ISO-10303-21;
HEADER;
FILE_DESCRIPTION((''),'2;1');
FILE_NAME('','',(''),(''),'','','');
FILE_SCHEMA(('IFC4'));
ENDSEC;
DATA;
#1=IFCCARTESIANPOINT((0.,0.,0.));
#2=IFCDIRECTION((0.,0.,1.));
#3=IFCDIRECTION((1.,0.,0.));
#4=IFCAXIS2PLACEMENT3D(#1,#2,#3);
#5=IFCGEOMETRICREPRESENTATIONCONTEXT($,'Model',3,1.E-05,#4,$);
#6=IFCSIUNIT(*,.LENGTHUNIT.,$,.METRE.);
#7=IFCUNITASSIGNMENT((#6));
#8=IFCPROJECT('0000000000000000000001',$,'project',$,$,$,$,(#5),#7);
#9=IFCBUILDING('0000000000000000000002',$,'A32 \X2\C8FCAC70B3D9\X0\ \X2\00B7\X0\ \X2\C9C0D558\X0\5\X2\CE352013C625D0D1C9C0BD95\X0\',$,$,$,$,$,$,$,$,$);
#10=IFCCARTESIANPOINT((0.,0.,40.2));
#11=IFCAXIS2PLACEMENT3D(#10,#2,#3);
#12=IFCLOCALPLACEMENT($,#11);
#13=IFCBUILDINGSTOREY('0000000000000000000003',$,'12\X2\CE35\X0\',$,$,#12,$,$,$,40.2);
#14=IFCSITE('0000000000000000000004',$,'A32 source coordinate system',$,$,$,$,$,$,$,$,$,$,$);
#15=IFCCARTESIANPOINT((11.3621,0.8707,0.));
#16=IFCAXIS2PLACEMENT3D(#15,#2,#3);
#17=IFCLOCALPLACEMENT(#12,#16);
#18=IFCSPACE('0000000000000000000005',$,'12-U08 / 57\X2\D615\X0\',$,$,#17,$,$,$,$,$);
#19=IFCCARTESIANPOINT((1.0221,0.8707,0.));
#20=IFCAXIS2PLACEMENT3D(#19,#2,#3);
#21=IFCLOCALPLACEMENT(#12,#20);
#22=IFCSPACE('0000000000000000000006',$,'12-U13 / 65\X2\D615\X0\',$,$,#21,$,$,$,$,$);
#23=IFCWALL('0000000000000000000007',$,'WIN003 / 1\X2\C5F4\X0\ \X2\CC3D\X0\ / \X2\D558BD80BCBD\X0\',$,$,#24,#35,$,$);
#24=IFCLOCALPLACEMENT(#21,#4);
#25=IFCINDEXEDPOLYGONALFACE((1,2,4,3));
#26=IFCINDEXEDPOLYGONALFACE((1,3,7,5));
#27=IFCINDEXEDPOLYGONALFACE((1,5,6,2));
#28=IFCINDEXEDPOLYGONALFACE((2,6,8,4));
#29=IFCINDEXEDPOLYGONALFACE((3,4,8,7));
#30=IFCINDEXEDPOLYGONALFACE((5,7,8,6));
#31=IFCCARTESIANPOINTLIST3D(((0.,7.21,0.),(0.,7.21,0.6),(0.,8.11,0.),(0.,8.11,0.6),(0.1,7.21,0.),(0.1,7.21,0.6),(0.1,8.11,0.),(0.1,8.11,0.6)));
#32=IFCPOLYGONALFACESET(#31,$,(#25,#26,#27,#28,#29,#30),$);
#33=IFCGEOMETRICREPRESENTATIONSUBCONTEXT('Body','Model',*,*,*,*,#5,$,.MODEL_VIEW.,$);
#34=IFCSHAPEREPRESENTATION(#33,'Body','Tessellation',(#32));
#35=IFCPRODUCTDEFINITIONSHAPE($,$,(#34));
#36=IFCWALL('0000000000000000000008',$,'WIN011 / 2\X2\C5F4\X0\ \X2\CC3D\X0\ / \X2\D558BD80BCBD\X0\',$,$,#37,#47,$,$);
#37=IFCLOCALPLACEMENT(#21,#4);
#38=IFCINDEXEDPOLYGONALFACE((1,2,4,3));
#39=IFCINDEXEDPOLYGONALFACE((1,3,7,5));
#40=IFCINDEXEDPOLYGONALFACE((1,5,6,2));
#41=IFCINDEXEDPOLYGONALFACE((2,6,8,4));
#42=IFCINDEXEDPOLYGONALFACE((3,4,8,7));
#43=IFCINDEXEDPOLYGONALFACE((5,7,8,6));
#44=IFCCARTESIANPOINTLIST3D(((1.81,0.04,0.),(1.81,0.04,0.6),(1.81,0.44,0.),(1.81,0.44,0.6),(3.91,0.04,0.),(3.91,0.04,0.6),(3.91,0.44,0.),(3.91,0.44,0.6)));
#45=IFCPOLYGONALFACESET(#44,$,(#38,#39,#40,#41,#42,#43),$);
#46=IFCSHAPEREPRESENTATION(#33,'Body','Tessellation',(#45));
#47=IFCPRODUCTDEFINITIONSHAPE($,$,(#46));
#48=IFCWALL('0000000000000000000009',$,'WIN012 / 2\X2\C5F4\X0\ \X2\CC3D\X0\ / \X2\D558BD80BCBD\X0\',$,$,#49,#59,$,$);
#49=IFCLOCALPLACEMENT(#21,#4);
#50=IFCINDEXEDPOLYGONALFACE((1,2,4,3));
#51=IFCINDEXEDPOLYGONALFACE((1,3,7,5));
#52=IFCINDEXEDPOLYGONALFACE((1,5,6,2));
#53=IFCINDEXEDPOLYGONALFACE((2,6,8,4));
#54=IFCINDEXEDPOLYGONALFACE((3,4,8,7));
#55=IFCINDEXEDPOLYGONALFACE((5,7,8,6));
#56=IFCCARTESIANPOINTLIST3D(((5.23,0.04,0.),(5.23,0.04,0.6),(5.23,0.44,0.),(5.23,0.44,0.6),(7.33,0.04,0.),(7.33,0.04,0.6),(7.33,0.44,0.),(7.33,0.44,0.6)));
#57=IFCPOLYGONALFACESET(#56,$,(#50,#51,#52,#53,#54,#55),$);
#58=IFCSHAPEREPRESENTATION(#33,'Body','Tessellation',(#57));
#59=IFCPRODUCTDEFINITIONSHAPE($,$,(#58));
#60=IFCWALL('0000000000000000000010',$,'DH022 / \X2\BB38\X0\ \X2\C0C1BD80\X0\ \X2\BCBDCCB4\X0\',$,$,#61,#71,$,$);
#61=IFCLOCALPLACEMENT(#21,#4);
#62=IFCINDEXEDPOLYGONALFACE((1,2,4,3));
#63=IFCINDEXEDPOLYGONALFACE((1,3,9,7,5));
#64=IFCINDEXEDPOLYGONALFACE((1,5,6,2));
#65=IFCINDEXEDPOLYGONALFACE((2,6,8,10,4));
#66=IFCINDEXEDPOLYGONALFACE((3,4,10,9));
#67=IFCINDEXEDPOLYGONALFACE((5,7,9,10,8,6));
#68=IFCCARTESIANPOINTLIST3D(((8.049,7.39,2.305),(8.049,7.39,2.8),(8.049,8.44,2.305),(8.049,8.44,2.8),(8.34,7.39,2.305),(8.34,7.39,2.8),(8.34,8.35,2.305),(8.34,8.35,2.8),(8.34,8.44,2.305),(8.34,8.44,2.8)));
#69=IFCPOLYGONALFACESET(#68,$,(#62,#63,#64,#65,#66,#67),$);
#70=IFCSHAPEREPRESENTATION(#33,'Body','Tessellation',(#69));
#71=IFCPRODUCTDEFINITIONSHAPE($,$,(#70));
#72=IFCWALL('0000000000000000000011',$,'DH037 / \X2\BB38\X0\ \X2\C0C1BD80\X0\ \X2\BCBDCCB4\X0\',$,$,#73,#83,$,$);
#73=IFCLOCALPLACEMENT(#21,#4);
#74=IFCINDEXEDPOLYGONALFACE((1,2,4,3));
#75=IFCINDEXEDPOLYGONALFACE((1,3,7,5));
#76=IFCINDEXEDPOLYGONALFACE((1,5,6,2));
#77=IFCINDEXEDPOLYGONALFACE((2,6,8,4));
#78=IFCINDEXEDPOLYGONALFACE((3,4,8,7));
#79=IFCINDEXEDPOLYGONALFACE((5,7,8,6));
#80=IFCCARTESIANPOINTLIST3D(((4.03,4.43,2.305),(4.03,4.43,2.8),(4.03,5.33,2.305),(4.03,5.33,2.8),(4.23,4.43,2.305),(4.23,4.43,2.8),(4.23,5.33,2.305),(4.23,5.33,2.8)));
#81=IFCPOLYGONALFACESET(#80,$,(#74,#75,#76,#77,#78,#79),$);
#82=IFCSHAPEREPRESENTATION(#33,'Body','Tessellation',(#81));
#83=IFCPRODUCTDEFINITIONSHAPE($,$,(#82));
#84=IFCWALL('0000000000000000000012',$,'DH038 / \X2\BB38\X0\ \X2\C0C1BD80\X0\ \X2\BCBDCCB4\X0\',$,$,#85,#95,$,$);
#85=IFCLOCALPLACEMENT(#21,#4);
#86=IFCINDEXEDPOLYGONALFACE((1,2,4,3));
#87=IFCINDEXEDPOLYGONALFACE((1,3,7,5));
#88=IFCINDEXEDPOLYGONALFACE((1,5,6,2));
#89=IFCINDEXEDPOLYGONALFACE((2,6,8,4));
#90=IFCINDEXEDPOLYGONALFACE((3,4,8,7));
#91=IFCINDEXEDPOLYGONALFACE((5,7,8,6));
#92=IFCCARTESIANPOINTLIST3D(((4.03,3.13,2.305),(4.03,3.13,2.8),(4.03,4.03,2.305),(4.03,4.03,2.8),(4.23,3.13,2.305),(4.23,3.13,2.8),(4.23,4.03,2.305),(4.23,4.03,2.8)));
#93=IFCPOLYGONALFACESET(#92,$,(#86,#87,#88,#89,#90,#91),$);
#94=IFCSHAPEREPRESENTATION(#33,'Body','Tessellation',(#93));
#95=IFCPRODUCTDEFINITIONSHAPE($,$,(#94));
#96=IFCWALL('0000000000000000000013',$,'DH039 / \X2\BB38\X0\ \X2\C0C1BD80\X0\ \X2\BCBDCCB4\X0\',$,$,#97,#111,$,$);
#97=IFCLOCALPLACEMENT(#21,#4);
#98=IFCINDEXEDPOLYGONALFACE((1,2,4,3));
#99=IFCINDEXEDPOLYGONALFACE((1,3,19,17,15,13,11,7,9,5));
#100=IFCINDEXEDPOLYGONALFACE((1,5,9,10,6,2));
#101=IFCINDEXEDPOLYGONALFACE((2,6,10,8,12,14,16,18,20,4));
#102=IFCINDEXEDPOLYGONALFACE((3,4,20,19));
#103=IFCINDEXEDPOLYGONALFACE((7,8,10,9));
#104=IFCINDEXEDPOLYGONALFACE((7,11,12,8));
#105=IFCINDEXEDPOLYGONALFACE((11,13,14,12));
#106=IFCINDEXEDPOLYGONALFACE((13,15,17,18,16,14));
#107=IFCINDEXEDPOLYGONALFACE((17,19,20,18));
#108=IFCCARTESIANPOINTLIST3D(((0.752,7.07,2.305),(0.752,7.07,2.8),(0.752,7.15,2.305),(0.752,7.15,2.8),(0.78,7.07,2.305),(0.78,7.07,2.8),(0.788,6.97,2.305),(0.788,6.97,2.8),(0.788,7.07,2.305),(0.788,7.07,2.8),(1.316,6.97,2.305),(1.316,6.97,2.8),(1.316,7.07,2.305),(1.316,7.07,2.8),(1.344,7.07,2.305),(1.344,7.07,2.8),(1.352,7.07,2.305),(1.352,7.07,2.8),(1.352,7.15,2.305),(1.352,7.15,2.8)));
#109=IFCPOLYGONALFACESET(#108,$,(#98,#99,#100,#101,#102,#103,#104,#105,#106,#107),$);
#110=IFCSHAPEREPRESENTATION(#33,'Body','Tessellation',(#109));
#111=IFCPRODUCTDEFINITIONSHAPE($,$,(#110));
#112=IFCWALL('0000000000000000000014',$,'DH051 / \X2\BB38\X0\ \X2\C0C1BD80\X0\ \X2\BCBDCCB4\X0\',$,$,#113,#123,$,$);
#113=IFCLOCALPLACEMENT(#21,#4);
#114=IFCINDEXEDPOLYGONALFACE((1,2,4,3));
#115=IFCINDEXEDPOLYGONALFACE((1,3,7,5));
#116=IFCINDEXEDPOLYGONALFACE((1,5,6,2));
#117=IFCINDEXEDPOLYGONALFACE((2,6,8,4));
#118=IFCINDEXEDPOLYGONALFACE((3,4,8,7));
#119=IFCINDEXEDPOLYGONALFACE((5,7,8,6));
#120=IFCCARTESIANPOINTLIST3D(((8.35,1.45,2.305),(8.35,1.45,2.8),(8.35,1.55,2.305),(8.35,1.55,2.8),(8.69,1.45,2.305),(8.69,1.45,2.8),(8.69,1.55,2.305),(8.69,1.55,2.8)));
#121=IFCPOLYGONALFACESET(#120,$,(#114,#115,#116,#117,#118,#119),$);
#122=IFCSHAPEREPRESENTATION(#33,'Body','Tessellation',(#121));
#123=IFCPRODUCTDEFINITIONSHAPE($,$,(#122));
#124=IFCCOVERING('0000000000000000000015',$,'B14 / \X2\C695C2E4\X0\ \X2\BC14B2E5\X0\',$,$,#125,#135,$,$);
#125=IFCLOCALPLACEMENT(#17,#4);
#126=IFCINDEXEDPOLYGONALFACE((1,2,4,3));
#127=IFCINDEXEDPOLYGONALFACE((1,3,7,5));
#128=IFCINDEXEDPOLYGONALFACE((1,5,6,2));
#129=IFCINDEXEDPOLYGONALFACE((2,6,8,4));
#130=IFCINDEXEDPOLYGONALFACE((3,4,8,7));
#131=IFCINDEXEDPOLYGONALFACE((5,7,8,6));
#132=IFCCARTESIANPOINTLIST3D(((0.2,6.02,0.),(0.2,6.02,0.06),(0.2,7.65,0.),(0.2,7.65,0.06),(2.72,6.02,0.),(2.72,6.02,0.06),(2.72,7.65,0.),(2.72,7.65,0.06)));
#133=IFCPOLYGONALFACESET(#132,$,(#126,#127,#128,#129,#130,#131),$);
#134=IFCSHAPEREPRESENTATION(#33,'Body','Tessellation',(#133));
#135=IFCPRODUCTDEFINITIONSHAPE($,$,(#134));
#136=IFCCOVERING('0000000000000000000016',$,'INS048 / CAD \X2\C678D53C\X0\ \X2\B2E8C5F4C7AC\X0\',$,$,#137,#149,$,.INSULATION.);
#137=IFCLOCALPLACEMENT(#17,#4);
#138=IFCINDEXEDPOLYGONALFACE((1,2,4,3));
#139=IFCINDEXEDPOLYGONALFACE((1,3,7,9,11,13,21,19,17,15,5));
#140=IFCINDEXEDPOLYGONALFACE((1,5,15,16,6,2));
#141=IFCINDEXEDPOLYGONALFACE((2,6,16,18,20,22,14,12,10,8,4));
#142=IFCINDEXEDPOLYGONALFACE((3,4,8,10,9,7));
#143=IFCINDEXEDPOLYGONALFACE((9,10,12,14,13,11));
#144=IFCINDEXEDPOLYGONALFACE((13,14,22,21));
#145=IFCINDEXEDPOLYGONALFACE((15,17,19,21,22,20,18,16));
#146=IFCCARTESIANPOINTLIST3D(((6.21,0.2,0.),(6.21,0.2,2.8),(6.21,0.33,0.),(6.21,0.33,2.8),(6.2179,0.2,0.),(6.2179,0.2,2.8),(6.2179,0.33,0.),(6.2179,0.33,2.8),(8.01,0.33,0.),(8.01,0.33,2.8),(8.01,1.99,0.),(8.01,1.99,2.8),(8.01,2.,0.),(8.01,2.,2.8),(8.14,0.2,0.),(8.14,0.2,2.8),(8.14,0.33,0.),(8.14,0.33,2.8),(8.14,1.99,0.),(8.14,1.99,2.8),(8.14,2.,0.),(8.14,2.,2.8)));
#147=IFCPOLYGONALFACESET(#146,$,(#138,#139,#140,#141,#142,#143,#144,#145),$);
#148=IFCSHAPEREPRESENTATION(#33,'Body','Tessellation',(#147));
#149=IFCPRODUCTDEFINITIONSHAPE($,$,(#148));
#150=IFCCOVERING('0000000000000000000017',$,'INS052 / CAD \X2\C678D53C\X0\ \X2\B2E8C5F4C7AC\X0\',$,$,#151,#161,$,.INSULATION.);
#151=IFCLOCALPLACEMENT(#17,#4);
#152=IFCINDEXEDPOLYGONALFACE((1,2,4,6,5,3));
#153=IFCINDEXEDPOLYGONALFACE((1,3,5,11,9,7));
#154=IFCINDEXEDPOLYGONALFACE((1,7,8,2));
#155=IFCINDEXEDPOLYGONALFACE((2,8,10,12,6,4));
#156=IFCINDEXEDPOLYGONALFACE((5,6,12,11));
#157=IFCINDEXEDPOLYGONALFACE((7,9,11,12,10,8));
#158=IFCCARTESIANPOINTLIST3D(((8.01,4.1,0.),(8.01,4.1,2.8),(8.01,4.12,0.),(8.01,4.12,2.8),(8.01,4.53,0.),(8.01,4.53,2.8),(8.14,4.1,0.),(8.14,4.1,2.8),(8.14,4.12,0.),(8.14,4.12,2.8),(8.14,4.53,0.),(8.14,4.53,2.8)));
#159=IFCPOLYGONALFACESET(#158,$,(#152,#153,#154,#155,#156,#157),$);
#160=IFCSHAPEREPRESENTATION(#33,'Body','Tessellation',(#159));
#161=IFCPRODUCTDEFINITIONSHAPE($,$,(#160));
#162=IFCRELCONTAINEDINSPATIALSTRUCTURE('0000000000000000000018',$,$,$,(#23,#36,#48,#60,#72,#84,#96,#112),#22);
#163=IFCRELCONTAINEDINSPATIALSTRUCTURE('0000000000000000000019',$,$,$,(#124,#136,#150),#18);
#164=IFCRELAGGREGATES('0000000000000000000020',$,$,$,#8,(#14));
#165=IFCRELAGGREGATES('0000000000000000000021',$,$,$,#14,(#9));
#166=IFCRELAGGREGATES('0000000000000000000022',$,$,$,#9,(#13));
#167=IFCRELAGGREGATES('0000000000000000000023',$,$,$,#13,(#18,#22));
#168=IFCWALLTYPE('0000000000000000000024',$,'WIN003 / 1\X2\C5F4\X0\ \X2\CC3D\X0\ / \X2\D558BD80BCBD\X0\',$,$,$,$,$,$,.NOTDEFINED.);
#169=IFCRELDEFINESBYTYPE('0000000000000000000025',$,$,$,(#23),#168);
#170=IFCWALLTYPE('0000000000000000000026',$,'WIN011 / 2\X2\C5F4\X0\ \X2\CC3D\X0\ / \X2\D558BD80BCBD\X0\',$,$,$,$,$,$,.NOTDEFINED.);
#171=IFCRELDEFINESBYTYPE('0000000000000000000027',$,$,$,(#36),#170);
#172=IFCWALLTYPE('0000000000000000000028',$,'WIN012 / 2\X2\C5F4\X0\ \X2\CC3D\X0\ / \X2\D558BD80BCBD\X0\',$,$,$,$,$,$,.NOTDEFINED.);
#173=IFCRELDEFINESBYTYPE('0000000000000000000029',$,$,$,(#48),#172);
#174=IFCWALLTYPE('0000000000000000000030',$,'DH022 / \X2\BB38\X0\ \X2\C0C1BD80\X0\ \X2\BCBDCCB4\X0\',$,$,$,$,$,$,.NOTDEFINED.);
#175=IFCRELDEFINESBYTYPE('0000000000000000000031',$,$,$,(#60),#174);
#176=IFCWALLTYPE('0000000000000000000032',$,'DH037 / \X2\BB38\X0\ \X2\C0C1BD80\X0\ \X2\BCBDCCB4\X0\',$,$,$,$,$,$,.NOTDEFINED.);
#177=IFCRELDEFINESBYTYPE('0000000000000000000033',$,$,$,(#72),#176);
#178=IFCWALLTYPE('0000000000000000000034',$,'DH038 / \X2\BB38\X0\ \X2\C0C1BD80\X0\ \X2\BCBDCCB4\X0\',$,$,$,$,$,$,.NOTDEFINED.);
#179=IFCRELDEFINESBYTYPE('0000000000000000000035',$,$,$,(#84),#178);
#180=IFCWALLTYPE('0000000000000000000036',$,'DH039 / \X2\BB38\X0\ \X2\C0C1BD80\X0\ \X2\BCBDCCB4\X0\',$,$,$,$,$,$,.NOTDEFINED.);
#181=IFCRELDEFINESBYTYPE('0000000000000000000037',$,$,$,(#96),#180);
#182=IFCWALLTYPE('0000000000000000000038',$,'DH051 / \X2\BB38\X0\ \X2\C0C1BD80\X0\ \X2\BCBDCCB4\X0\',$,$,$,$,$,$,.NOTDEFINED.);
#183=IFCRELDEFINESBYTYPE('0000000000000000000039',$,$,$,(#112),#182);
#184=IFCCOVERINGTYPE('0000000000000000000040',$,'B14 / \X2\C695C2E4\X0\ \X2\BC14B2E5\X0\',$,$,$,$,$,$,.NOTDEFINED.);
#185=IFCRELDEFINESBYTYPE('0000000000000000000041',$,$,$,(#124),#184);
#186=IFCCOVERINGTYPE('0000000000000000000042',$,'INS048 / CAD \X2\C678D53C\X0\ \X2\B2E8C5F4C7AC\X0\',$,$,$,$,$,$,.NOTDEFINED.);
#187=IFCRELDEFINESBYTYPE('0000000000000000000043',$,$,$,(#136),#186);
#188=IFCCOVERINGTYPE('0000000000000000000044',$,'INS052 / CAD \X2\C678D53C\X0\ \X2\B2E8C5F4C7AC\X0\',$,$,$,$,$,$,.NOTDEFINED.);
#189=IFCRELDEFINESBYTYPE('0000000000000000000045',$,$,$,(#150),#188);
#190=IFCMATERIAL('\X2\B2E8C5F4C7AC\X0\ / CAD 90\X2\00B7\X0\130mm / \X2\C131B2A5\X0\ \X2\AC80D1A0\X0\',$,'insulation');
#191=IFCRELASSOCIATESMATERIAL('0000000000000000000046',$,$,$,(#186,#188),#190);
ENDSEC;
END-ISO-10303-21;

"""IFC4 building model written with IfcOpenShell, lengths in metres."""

from ifc_helpers import new_model, si_unit, frame, origin, origin_with_axes, place, context, subcontext, project, spatial, polyline, outline, extrude, source, transform, mapped, material, type_object, type_shapes, element, save


model = new_model("IFC4")

# Units and contexts
model_context = context("Model", 3, precision=1e-05, world=origin_with_axes())
body_context = subcontext(model_context, "Body", "Model", "MODEL_VIEW")
ifc_project = project(units=[si_unit("LENGTHUNIT", "METRE")], contexts=[model_context])

# Site, building, storey, space
site = spatial("IfcSite", under=ifc_project, Name="A32 source coordinate system")
building = spatial("IfcBuilding", under=site, Name="A32 주거동 · 지하5층–옥탑지붕")
storey_placement = place(None, frame((0.0, 0.0, 40.2), z_axis=(0.0, 0.0, 1.0), x_axis=(1.0, 0.0, 0.0)))
storey = spatial("IfcBuildingStorey", under=building, at=storey_placement, Name="12층", Elevation=40.2)
space_1_placement = place(storey_placement, frame((11.3621, 0.8707, 0.0), z_axis=(0.0, 0.0, 1.0), x_axis=(1.0, 0.0, 0.0)))
space_1 = spatial("IfcSpace", under=storey, at=space_1_placement, Name="12-U08 / 57형")

# Shared definitions
space_2_placement = place(storey_placement, frame((1.0221, 0.8707, 0.0), z_axis=(0.0, 0.0, 1.0), x_axis=(1.0, 0.0, 0.0)))
space_2 = spatial("IfcSpace", under=storey, at=space_2_placement, Name="12-U13 / 65형")

# Walls
wall_type_1 = type_object("IfcWallType", Name="WIN003 / 1열 창 / 하부벽", PredefinedType="NOTDEFINED")
shared_shape_1 = source(origin(), body_context, "Body", "SweptSolid", [
    extrude(outline(polyline([(0.0, 8.11), (0.1, 8.11), (0.1, 7.21), (0.0, 7.21), (0.0, 8.11)])), origin(), (0.0, 0.0, 1.0), 0.6),
])
type_shapes(wall_type_1, [shared_shape_1])
wall_1_placement = place(space_2_placement, origin_with_axes())
element("IfcWall", 1, at=wall_1_placement, inside=space_2, type_object=wall_type_1, Name="WIN003 / 1열 창 / 하부벽", context=body_context, shape_type="MappedRepresentation", body=[
    mapped(shared_shape_1, transform((0.0, 0.0, 0.0), scale=1.0)),
])
wall_type_2 = type_object("IfcWallType", Name="WIN011 / 2열 창 / 하부벽", PredefinedType="NOTDEFINED")
shared_shape_2 = source(origin(), body_context, "Body", "SweptSolid", [
    extrude(outline(polyline([(1.81, 0.44), (3.91, 0.44), (3.91, 0.04), (1.81, 0.04), (1.81, 0.44)])), origin(), (0.0, 0.0, 1.0), 0.6),
])
type_shapes(wall_type_2, [shared_shape_2])
wall_2_placement = place(space_2_placement, origin_with_axes())
element("IfcWall", 2, at=wall_2_placement, inside=space_2, type_object=wall_type_2, Name="WIN011 / 2열 창 / 하부벽", context=body_context, shape_type="MappedRepresentation", body=[
    mapped(shared_shape_2, transform((0.0, 0.0, 0.0), scale=1.0)),
])
wall_type_3 = type_object("IfcWallType", Name="WIN012 / 2열 창 / 하부벽", PredefinedType="NOTDEFINED")
shared_shape_3 = source(origin(), body_context, "Body", "SweptSolid", [
    extrude(outline(polyline([(5.23, 0.44), (7.33, 0.44), (7.33, 0.04), (5.23, 0.04), (5.23, 0.44)])), origin(), (0.0, 0.0, 1.0), 0.6),
])
type_shapes(wall_type_3, [shared_shape_3])
wall_3_placement = place(space_2_placement, origin_with_axes())
element("IfcWall", 3, at=wall_3_placement, inside=space_2, type_object=wall_type_3, Name="WIN012 / 2열 창 / 하부벽", context=body_context, shape_type="MappedRepresentation", body=[
    mapped(shared_shape_3, transform((0.0, 0.0, 0.0), scale=1.0)),
])
wall_type_4 = type_object("IfcWallType", Name="DH022 / 문 상부 벽체", PredefinedType="NOTDEFINED")
shared_shape_4 = source(origin(), body_context, "Body", "SweptSolid", [
    extrude(outline(polyline([(8.049, 7.39), (8.049, 8.44), (8.34, 8.44), (8.34, 8.35), (8.34, 8.35), (8.34, 7.39), (8.049, 7.39)])), frame((0.0, 0.0, 2.305)), (0.0, 0.0, 1.0), 0.495),
])
type_shapes(wall_type_4, [shared_shape_4])
wall_4_placement = place(space_2_placement, origin_with_axes())
element("IfcWall", 4, at=wall_4_placement, inside=space_2, type_object=wall_type_4, Name="DH022 / 문 상부 벽체", context=body_context, shape_type="MappedRepresentation", body=[
    mapped(shared_shape_4, transform((0.0, 0.0, 0.0), scale=1.0)),
])
wall_type_5 = type_object("IfcWallType", Name="DH037 / 문 상부 벽체", PredefinedType="NOTDEFINED")
shared_shape_5 = source(origin(), body_context, "Body", "SweptSolid", [
    extrude(outline(polyline([(4.23, 5.33), (4.23, 4.43), (4.03, 4.43), (4.03, 5.33), (4.23, 5.33)])), frame((0.0, 0.0, 2.305)), (0.0, 0.0, 1.0), 0.495),
])
type_shapes(wall_type_5, [shared_shape_5])
wall_5_placement = place(space_2_placement, origin_with_axes())
element("IfcWall", 5, at=wall_5_placement, inside=space_2, type_object=wall_type_5, Name="DH037 / 문 상부 벽체", context=body_context, shape_type="MappedRepresentation", body=[
    mapped(shared_shape_5, transform((0.0, 0.0, 0.0), scale=1.0)),
])
wall_type_6 = type_object("IfcWallType", Name="DH038 / 문 상부 벽체", PredefinedType="NOTDEFINED")
shared_shape_6 = source(origin(), body_context, "Body", "SweptSolid", [
    extrude(outline(polyline([(4.23, 4.03), (4.23, 3.13), (4.03, 3.13), (4.03, 4.03), (4.23, 4.03)])), frame((0.0, 0.0, 2.305)), (0.0, 0.0, 1.0), 0.495),
])
type_shapes(wall_type_6, [shared_shape_6])
wall_6_placement = place(space_2_placement, origin_with_axes())
element("IfcWall", 6, at=wall_6_placement, inside=space_2, type_object=wall_type_6, Name="DH038 / 문 상부 벽체", context=body_context, shape_type="MappedRepresentation", body=[
    mapped(shared_shape_6, transform((0.0, 0.0, 0.0), scale=1.0)),
])
wall_type_7 = type_object("IfcWallType", Name="DH039 / 문 상부 벽체", PredefinedType="NOTDEFINED")
shared_shape_7 = source(origin(), body_context, "Body", "SweptSolid", [
    extrude(outline(polyline([(1.316, 7.07), (1.316, 6.97), (0.788, 6.97), (0.788, 7.07), (0.78, 7.07), (0.752, 7.07), (0.752, 7.15), (1.352, 7.15), (1.352, 7.07), (1.344, 7.07), (1.316, 7.07)])), frame((0.0, 0.0, 2.305)), (0.0, 0.0, 1.0), 0.495),
])
type_shapes(wall_type_7, [shared_shape_7])
wall_7_placement = place(space_2_placement, origin_with_axes())
element("IfcWall", 7, at=wall_7_placement, inside=space_2, type_object=wall_type_7, Name="DH039 / 문 상부 벽체", context=body_context, shape_type="MappedRepresentation", body=[
    mapped(shared_shape_7, transform((0.0, 0.0, 0.0), scale=1.0)),
])
wall_type_8 = type_object("IfcWallType", Name="DH051 / 문 상부 벽체", PredefinedType="NOTDEFINED")
shared_shape_8 = source(origin(), body_context, "Body", "SweptSolid", [
    extrude(outline(polyline([(8.69, 1.55), (8.69, 1.45), (8.35, 1.45), (8.35, 1.55), (8.69, 1.55)])), frame((0.0, 0.0, 2.305)), (0.0, 0.0, 1.0), 0.495),
])
type_shapes(wall_type_8, [shared_shape_8])
wall_8_placement = place(space_2_placement, origin_with_axes())
element("IfcWall", 8, at=wall_8_placement, inside=space_2, type_object=wall_type_8, Name="DH051 / 문 상부 벽체", context=body_context, shape_type="MappedRepresentation", body=[
    mapped(shared_shape_8, transform((0.0, 0.0, 0.0), scale=1.0)),
])

# Coverings
covering_type_1 = type_object("IfcCoveringType", Name="B14 / 욕실 바닥", PredefinedType="NOTDEFINED")
shared_shape_9 = source(origin(), body_context, "Body", "SweptSolid", [
    extrude(outline(polyline([(0.2, 7.65), (2.72, 7.65), (2.72, 6.02), (0.2, 6.02), (0.2, 7.65)])), origin(), (0.0, 0.0, 1.0), 0.06),
])
type_shapes(covering_type_1, [shared_shape_9])
covering_1_placement = place(space_1_placement, origin_with_axes())
element("IfcCovering", 9, at=covering_1_placement, inside=space_1, type_object=covering_type_1, Name="B14 / 욕실 바닥", context=body_context, shape_type="MappedRepresentation", body=[
    mapped(shared_shape_9, transform((0.0, 0.0, 0.0), scale=1.0)),
])
ifc_material = material(Name="단열재 / CAD 90·130mm / 성능 검토", Category="insulation")
covering_type_2 = type_object("IfcCoveringType", Name="INS048 / CAD 외피 단열재", PredefinedType="NOTDEFINED", material=ifc_material)
shared_shape_10 = source(origin(), body_context, "Body", "SweptSolid", [
    extrude(outline(polyline([(8.01, 1.99), (8.01, 2.0), (8.14, 2.0), (8.14, 1.99), (8.14, 0.33), (8.14, 0.2), (6.2179, 0.2), (6.21, 0.2), (6.21, 0.33), (6.2179, 0.33), (8.01, 0.33), (8.01, 1.99)])), origin(), (0.0, 0.0, 1.0), 2.8),
])
type_shapes(covering_type_2, [shared_shape_10])
covering_2_placement = place(space_1_placement, origin_with_axes())
element("IfcCovering", 10, at=covering_2_placement, inside=space_1, type_object=covering_type_2, Name="INS048 / CAD 외피 단열재", PredefinedType="INSULATION", context=body_context, shape_type="MappedRepresentation", body=[
    mapped(shared_shape_10, transform((0.0, 0.0, 0.0), scale=1.0)),
])
covering_type_3 = type_object("IfcCoveringType", Name="INS052 / CAD 외피 단열재", PredefinedType="NOTDEFINED", material=ifc_material)
shared_shape_11 = source(origin(), body_context, "Body", "SweptSolid", [
    extrude(outline(polyline([(8.14, 4.1), (8.01, 4.1), (8.01, 4.12), (8.01, 4.53), (8.14, 4.53), (8.14, 4.12), (8.14, 4.1)])), origin(), (0.0, 0.0, 1.0), 2.8),
])
type_shapes(covering_type_3, [shared_shape_11])
covering_3_placement = place(space_1_placement, origin_with_axes())
element("IfcCovering", 11, at=covering_3_placement, inside=space_1, type_object=covering_type_3, Name="INS052 / CAD 외피 단열재", PredefinedType="INSULATION", context=body_context, shape_type="MappedRepresentation", body=[
    mapped(shared_shape_11, transform((0.0, 0.0, 0.0), scale=1.0)),
])

save(model, "model.ifc")
